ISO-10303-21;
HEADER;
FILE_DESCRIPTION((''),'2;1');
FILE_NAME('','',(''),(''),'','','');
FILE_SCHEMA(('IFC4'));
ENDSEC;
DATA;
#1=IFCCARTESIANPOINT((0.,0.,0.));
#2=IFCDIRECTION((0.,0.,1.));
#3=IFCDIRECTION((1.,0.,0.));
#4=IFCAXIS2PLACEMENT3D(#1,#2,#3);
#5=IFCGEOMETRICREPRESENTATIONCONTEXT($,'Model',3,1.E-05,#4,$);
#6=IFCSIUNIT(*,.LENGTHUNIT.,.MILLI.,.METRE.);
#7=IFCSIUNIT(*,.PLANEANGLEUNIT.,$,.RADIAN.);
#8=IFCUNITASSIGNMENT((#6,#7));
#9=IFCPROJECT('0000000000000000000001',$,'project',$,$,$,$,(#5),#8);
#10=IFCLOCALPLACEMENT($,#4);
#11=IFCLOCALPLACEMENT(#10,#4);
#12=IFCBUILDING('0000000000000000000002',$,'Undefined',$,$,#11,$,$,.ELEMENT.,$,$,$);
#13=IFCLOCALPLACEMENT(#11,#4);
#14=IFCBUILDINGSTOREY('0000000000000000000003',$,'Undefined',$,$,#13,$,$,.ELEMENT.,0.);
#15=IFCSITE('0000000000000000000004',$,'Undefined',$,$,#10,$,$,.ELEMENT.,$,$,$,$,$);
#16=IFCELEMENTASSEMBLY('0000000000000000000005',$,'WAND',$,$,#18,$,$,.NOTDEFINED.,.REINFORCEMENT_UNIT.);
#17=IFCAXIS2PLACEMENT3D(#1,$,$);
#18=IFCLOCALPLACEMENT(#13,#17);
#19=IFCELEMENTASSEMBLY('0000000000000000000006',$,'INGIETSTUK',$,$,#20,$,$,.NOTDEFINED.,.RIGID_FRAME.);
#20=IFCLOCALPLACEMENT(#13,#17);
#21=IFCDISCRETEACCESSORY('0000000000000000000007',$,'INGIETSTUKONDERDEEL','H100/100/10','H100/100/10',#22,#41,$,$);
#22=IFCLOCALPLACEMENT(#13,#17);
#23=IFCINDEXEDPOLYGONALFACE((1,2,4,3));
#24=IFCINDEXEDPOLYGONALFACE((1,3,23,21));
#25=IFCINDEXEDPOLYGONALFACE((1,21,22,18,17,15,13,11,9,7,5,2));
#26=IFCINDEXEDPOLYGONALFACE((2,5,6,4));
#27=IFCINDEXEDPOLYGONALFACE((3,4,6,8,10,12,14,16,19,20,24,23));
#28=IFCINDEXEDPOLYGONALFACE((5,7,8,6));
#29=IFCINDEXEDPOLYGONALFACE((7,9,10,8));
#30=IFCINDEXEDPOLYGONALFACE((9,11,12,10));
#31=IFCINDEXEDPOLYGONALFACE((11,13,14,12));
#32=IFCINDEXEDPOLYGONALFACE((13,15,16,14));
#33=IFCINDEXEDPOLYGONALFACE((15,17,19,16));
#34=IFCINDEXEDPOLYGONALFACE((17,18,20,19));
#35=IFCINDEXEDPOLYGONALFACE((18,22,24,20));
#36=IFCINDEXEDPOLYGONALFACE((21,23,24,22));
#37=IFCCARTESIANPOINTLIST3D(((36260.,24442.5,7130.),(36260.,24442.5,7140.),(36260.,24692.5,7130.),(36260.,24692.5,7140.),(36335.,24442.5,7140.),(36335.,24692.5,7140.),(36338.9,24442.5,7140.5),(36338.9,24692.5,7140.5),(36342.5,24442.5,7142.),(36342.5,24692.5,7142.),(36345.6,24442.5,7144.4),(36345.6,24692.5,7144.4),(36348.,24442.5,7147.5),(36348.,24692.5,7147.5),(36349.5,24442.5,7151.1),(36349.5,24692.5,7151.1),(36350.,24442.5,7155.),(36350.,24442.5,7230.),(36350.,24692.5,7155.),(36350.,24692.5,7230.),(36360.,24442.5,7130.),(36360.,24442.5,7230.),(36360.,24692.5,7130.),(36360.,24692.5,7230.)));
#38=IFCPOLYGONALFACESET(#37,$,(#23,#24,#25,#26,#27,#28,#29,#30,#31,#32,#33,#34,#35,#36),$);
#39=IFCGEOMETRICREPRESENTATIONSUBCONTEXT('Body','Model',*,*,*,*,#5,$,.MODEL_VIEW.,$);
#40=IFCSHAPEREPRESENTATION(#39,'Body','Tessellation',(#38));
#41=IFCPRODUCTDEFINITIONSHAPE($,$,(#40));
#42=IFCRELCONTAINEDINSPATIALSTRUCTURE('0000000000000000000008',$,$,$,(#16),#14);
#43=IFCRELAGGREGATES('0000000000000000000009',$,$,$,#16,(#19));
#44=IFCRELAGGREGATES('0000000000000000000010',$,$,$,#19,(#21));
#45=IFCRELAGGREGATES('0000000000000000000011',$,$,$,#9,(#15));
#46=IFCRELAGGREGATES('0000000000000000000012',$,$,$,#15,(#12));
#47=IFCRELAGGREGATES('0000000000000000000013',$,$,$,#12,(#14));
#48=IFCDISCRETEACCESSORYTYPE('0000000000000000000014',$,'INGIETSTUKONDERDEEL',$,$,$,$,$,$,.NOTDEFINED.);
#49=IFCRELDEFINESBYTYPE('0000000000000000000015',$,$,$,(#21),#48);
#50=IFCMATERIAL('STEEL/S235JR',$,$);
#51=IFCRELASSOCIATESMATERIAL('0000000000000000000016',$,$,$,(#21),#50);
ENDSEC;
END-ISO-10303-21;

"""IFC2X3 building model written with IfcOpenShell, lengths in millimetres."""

from ifc_helpers import new_model, si_unit, frame, frame_2d, origin_with_axes, place, context, subcontext, project, spatial, l_section, extrude, material, type_object, element, aggregate, save


model = new_model("IFC2X3")

# Units and contexts
model_context = context("Model", 3, precision=1e-05, world=origin_with_axes())
body_context = subcontext(model_context, "Body", "Model", "MODEL_VIEW")
ifc_project = project(units=[si_unit("LENGTHUNIT", "METRE", prefix="MILLI"), si_unit("PLANEANGLEUNIT", "RADIAN")], contexts=[model_context])

# Site, building, storey
site_placement = place(None, origin_with_axes())
site = spatial("IfcSite", under=ifc_project, at=site_placement, Name="Undefined", CompositionType="ELEMENT")
building_placement = place(site_placement, origin_with_axes())
building = spatial("IfcBuilding", under=site, at=building_placement, Name="Undefined", CompositionType="ELEMENT")
storey_placement = place(building_placement, origin_with_axes())
storey = spatial("IfcBuildingStorey", under=building, at=storey_placement, Name="Undefined", CompositionType="ELEMENT", Elevation=0.0)

# Element assemblies
assembly_1_placement = place(storey_placement, origin_with_axes())
assembly_1 = element("IfcElementAssembly", 1, at=assembly_1_placement, inside=storey, Name="WAND", AssemblyPlace="NOTDEFINED", PredefinedType="REINFORCEMENT_UNIT")
assembly_2_placement = place(assembly_1_placement, origin_with_axes())
assembly_2 = element("IfcElementAssembly", 2, at=assembly_2_placement, Name="INGIETSTUK", AssemblyPlace="NOTDEFINED", PredefinedType="RIGID_FRAME")
ifc_material_1 = material(Name="STEEL/S235JR")

aggregate(assembly_1, [assembly_2])

# Discrete accessory
discrete_accessory_type = type_object("IfcDiscreteAccessoryType", Name="INGIETSTUKONDERDEEL")
discrete_accessory_1_placement = place(assembly_2_placement, frame((36310.0, 24692.5, 7180.0), z_axis=(0.0, 0.0, 1.0), x_axis=(0.0, -1.0, 0.0)))
discrete_accessory_1 = element("IfcDiscreteAccessory", 3, at=discrete_accessory_1_placement, type_object=discrete_accessory_type, material=ifc_material_1, Name="INGIETSTUKONDERDEEL", Description="H100/100/10", ObjectType="H100/100/10", context=body_context, shape_type="SweptSolid", body=[
    extrude(l_section(Depth=100.0, Width=100.0, Thickness=10.0, FilletRadius=15.0, at=frame_2d((0.0, 0.0), x_axis=(1.0, 0.0))), frame((250.0, 0.0, 0.0), z_axis=(-1.0, 0.0, 0.0), x_axis=(0.0, -1.0, 0.0)), (0.0, 0.0, 1.0), 250.0),
])
aggregate(assembly_2, [discrete_accessory_1])

save(model, "model.ifc")
